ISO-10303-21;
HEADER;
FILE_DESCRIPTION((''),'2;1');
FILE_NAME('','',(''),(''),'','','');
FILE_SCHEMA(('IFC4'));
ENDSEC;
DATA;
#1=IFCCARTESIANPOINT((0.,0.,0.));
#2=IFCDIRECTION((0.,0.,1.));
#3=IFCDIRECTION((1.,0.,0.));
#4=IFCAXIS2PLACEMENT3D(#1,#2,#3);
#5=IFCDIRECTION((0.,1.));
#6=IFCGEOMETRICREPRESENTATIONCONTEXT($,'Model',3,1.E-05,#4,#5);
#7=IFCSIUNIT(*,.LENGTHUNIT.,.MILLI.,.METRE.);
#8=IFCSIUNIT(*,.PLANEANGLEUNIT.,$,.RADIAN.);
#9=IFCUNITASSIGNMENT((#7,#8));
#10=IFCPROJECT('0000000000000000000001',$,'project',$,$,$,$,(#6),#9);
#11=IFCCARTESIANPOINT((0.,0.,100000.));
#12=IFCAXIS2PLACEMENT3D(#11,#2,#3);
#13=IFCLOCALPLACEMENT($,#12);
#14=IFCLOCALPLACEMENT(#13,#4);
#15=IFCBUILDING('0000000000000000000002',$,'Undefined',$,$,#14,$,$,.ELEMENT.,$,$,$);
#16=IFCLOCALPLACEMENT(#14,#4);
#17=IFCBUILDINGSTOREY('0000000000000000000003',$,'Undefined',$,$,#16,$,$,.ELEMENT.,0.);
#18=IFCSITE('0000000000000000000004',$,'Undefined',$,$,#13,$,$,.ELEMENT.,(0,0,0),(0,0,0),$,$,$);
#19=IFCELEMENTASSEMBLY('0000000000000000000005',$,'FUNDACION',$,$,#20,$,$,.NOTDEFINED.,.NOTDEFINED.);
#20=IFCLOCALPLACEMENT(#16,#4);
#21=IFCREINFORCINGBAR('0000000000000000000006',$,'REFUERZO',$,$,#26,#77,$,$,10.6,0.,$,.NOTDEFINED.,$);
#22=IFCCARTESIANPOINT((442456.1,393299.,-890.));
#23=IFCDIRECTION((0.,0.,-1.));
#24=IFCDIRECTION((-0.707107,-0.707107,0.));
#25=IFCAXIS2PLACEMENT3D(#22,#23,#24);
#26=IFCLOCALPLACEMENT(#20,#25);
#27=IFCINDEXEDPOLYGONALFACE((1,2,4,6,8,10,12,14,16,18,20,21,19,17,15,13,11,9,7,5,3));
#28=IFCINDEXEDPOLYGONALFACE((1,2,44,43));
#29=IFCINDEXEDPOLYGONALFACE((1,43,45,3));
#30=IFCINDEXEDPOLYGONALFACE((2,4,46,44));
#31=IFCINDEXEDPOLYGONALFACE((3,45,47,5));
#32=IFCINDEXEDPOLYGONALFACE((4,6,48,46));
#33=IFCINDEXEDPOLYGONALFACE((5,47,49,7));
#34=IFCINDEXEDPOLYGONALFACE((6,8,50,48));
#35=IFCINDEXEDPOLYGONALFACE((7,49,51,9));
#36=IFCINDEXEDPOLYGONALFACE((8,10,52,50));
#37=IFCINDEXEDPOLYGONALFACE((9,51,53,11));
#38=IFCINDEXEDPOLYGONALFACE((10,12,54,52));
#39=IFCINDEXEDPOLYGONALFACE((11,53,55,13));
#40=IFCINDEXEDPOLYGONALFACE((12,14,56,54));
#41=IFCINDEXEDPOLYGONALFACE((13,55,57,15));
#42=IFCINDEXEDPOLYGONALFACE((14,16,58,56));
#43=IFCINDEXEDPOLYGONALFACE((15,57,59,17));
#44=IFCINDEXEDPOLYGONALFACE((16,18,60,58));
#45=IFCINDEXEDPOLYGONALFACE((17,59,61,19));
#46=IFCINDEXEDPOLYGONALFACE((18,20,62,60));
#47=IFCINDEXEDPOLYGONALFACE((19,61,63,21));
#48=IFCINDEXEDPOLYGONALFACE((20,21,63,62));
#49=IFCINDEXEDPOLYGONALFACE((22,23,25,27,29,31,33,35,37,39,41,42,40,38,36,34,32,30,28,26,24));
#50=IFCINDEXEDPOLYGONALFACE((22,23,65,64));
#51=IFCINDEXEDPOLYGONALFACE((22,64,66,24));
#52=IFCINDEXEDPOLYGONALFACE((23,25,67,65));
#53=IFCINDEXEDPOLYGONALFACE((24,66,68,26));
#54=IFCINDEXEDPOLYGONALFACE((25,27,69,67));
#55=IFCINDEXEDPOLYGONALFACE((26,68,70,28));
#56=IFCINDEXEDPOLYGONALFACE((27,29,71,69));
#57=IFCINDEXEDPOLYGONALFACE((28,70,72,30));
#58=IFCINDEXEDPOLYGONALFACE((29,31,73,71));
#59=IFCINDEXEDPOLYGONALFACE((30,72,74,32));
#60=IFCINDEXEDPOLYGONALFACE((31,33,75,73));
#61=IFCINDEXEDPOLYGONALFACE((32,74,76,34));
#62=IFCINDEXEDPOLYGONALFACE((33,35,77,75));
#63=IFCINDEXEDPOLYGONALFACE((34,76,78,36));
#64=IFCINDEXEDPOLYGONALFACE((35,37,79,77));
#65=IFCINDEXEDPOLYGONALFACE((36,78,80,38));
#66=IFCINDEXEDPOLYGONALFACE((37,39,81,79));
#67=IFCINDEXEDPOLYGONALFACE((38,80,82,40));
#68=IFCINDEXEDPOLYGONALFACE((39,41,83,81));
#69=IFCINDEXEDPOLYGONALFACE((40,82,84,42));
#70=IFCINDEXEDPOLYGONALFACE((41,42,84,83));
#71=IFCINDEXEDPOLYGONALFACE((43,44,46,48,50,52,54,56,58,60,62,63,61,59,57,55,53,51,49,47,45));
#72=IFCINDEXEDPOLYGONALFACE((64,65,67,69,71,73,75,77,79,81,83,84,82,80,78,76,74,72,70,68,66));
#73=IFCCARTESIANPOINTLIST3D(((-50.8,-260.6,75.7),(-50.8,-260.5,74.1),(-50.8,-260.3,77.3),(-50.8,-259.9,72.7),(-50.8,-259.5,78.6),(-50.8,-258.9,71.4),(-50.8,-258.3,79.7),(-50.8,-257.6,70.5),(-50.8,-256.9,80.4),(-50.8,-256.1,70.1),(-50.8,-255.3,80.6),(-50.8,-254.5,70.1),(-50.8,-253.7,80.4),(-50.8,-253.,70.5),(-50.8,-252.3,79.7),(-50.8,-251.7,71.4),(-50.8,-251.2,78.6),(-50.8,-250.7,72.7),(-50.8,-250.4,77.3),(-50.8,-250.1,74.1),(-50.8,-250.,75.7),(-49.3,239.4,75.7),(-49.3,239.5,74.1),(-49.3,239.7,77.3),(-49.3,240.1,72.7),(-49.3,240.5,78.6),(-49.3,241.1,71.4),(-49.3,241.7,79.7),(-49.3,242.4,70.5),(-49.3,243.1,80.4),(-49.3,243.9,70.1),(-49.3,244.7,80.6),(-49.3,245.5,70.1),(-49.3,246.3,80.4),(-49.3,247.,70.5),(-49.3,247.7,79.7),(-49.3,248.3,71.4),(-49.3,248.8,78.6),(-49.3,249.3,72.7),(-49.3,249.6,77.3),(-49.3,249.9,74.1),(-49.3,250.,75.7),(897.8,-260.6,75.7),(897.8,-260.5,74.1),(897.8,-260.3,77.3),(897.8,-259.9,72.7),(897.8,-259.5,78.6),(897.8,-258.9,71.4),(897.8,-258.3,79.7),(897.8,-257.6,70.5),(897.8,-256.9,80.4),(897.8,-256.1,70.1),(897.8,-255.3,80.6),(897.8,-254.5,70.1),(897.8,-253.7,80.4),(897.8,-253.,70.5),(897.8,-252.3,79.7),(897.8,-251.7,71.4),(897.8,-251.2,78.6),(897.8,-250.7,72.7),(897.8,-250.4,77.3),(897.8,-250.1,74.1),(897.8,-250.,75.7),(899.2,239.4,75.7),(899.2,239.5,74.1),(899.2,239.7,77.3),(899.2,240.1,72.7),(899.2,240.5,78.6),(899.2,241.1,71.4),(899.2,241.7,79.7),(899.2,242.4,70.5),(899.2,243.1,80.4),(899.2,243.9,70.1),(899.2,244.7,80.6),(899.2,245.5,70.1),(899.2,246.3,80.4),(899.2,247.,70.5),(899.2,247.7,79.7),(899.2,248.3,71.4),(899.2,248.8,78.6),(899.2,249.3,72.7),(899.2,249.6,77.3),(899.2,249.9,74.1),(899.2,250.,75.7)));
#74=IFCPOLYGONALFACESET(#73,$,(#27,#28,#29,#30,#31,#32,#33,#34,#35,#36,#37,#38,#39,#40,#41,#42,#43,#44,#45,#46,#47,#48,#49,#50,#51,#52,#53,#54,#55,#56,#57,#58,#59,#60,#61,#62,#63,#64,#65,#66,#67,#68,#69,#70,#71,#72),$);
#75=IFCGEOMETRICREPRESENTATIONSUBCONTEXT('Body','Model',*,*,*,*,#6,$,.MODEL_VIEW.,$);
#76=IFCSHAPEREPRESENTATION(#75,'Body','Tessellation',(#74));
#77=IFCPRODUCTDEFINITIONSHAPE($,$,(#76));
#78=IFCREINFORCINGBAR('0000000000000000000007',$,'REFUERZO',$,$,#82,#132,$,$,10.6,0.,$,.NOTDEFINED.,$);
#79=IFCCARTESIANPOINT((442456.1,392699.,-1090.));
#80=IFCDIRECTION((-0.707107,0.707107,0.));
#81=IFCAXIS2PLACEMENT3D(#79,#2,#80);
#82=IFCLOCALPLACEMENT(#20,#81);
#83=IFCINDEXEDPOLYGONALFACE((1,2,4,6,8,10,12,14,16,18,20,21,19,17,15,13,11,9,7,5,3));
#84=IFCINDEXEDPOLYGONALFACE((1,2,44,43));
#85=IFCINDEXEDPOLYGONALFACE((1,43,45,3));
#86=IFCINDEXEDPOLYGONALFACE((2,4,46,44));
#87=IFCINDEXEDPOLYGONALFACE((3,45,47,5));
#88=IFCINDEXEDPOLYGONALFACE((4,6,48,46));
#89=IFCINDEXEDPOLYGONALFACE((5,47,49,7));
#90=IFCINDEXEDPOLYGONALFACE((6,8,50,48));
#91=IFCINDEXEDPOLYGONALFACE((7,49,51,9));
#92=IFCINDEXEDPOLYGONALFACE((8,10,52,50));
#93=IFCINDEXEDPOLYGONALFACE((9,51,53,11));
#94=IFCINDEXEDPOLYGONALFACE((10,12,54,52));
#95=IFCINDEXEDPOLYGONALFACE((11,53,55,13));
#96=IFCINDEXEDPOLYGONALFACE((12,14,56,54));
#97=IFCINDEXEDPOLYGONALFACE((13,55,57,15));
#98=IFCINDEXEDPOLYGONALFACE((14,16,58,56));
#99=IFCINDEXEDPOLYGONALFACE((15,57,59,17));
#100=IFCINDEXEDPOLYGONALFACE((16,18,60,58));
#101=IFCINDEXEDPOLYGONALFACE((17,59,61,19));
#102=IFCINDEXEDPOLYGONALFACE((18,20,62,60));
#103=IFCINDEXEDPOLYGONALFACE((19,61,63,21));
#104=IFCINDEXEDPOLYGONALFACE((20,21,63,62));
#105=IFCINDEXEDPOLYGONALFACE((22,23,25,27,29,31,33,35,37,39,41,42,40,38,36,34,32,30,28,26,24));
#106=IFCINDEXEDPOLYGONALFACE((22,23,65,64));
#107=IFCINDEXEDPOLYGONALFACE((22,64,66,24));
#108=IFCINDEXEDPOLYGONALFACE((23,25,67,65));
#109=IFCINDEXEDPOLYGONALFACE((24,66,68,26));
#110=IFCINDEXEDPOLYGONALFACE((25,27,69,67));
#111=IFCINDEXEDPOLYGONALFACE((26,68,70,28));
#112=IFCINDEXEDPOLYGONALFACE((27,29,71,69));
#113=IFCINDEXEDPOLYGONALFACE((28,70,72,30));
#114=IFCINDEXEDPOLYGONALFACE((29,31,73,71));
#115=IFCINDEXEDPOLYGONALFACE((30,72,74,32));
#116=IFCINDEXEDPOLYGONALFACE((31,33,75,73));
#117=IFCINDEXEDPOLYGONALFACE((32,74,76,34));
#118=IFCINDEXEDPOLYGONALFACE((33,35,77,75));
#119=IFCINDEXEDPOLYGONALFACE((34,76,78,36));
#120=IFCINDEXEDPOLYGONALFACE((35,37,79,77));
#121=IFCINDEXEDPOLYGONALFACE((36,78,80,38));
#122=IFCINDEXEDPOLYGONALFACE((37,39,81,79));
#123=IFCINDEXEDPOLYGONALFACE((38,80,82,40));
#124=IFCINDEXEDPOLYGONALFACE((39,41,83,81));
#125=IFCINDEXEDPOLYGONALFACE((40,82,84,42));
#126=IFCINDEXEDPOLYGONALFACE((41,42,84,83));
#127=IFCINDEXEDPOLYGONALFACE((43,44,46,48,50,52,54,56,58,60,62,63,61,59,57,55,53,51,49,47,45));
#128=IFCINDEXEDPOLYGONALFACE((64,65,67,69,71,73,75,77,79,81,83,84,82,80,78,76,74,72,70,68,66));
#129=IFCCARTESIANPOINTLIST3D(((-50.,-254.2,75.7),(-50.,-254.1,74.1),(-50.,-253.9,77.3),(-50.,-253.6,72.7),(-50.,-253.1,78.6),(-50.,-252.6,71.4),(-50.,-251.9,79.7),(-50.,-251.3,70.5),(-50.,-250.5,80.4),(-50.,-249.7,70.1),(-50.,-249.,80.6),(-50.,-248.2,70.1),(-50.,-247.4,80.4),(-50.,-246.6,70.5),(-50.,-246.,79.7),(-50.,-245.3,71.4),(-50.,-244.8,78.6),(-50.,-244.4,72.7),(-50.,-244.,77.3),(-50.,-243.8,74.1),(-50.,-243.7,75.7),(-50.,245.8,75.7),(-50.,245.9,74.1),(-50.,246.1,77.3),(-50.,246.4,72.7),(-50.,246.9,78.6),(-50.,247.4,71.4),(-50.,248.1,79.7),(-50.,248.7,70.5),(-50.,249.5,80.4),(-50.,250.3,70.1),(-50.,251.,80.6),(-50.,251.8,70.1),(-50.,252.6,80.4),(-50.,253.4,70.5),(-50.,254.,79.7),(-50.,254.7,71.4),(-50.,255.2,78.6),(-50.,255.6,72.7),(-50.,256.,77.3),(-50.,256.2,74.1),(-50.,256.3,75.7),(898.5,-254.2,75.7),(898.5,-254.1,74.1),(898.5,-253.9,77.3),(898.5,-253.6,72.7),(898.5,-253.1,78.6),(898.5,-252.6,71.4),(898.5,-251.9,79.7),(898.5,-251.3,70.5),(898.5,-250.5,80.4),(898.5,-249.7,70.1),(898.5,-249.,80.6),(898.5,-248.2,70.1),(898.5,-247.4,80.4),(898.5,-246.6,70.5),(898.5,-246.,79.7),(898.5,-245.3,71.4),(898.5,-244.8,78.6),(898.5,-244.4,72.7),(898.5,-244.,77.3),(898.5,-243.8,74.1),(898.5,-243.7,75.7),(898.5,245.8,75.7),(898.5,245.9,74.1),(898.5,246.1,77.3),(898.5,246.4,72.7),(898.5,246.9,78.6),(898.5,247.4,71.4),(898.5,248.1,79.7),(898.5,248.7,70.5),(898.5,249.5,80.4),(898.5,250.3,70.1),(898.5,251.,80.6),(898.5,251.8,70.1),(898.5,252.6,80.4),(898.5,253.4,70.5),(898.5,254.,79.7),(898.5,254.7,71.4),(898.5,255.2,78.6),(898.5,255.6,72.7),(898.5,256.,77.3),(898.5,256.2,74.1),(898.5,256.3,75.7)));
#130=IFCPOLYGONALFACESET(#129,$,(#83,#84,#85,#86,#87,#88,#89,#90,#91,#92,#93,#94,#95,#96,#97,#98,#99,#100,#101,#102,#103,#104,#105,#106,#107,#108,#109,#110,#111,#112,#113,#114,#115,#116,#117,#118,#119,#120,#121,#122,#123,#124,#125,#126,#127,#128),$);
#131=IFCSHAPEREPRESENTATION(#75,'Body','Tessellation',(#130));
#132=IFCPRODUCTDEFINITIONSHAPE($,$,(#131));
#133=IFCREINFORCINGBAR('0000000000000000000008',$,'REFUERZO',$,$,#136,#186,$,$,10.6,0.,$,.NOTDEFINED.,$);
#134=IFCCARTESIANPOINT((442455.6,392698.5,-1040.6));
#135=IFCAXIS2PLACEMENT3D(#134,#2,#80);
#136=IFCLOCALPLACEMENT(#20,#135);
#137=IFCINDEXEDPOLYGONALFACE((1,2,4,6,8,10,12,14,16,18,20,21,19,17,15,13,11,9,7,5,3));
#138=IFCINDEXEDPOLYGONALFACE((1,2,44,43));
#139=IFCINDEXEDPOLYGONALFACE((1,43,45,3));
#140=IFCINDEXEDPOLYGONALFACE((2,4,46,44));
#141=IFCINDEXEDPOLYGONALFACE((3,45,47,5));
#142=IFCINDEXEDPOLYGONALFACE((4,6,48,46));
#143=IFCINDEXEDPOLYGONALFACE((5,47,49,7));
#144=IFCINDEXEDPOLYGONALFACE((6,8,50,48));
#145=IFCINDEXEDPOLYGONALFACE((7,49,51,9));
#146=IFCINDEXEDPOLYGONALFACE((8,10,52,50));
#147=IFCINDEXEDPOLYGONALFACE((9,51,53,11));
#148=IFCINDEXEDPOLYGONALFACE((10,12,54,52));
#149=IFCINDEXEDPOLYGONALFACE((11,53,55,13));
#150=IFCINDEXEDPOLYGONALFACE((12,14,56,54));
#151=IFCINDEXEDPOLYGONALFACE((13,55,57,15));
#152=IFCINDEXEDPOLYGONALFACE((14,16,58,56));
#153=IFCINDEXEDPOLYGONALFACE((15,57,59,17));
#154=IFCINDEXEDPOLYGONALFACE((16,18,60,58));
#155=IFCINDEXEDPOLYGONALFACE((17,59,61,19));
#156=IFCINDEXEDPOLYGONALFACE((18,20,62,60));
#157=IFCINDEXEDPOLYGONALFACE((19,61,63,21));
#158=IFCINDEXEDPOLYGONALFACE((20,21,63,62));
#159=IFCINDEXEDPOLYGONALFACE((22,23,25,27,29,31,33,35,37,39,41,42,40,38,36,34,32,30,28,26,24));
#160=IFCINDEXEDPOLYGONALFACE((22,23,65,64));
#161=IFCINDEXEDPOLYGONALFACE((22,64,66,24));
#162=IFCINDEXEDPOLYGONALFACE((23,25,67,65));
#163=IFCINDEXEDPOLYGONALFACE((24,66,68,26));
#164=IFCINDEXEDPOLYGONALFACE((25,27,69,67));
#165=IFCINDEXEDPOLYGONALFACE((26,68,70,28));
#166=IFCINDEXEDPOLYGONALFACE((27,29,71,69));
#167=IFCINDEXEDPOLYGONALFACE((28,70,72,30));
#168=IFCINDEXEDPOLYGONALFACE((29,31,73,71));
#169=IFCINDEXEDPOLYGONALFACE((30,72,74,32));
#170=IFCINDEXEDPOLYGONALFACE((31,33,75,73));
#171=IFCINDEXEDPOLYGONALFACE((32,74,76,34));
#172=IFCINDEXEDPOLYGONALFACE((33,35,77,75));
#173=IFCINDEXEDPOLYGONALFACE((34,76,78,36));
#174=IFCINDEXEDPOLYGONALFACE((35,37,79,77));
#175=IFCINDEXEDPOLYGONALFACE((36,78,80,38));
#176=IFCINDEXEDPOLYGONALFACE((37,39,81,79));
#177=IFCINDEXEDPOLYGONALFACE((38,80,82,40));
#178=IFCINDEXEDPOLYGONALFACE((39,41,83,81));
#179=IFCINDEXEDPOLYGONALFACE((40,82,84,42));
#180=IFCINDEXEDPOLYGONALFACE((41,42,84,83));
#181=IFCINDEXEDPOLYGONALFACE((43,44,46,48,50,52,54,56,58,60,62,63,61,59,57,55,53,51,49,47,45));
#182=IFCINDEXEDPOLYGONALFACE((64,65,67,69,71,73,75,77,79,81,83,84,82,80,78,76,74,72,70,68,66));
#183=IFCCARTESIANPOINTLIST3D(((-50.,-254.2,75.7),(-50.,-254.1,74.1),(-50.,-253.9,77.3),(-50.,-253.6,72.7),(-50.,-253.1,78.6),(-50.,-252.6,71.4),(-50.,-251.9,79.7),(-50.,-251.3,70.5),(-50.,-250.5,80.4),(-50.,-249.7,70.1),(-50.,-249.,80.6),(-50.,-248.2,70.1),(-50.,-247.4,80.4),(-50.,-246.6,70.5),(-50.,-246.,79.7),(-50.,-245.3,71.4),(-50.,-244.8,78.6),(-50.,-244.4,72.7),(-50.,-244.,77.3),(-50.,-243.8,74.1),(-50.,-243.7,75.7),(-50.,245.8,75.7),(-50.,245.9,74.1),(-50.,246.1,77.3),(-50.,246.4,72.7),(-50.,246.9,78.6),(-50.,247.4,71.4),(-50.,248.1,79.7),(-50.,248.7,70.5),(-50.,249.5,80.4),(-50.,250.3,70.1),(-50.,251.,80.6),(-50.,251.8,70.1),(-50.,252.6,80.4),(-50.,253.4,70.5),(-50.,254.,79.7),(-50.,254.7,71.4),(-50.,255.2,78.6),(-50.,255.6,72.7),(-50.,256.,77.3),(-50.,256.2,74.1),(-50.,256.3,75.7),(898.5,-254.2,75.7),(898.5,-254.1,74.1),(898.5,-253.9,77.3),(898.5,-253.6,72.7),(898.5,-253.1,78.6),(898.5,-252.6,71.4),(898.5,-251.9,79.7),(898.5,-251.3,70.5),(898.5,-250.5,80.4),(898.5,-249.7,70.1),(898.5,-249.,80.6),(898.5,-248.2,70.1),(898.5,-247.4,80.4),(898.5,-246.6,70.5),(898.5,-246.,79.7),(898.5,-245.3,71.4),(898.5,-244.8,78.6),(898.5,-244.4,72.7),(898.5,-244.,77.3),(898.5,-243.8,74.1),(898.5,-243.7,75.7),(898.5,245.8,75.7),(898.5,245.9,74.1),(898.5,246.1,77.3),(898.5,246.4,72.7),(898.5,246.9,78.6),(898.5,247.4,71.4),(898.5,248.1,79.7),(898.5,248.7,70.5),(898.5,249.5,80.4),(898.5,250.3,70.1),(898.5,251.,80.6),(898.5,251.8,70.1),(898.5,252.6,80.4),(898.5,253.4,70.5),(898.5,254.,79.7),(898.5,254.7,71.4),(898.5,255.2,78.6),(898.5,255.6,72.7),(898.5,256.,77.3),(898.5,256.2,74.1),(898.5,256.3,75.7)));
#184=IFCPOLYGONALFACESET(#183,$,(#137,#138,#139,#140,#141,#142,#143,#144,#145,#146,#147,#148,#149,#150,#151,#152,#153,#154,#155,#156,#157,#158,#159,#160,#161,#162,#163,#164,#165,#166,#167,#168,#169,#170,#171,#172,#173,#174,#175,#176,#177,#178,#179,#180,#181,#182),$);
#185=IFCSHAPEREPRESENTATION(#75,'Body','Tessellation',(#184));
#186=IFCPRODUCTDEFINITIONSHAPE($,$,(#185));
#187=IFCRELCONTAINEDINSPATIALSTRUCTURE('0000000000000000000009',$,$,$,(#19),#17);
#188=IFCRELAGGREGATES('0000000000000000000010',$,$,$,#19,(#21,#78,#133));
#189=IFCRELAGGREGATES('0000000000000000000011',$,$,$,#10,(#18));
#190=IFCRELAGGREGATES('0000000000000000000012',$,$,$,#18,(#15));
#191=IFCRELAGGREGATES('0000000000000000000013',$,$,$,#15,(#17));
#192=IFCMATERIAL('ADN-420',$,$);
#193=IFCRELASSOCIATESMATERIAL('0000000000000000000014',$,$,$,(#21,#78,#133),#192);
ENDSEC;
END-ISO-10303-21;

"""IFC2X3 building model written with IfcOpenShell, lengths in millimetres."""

from ifc_helpers import new_model, entity, si_unit, direction, frame, origin_with_axes, place, context, subcontext, project, spatial, source, transform, mapped, material, element, aggregate, save


model = new_model("IFC2X3")

# Units and contexts
model_context = context("Model", 3, precision=1e-05, world=origin_with_axes(), true_north=direction((0.0, 1.0)))
body_context = subcontext(model_context, "Body", "Model", "MODEL_VIEW")
ifc_project = project(units=[si_unit("LENGTHUNIT", "METRE", prefix="MILLI"), si_unit("PLANEANGLEUNIT", "RADIAN")], contexts=[model_context])

# Site, building, storey
site_placement = place(None, frame((0.0, 0.0, 100000.0), z_axis=(0.0, 0.0, 1.0), x_axis=(1.0, 0.0, 0.0)))
site = spatial("IfcSite", under=ifc_project, at=site_placement, Name="Undefined", CompositionType="ELEMENT", RefLatitude=(0, 0, 0), RefLongitude=(0, 0, 0))
building_placement = place(site_placement, origin_with_axes())
building = spatial("IfcBuilding", under=site, at=building_placement, Name="Undefined", CompositionType="ELEMENT")
storey_placement = place(building_placement, origin_with_axes())
storey = spatial("IfcBuildingStorey", under=building, at=storey_placement, Name="Undefined", CompositionType="ELEMENT", Elevation=0.0)

# Element assembly, reinforcing bars
assembly_1_placement = place(storey_placement, origin_with_axes())
assembly_1 = element("IfcElementAssembly", 1, at=assembly_1_placement, inside=storey, Name="FUNDACION", AssemblyPlace="NOTDEFINED", PredefinedType="NOTDEFINED")
ifc_material_1 = material(Name="ADN-420")
shared_shape_1 = source(origin_with_axes(), body_context, "Body", "AdvancedSweptSolid", [
    entity("IfcSweptDiskSolid", entity("IfcTrimmedCurve", entity("IfcLine", entity("IfcCartesianPoint", [0.0, 0.0, 0.0]), entity("IfcVector", entity("IfcDirection", [1.0, 0.0, 0.0]), 1.0)), [entity("IfcParameterValue", 0.0)], [entity("IfcParameterValue", 948.528137)], True, "PARAMETER"), 5.3, None, 0.0, 948.5),
])
shared_shape_2 = source(origin_with_axes(), body_context, "Body", "AdvancedSweptSolid", [
    entity("IfcSweptDiskSolid", entity("IfcTrimmedCurve", entity("IfcLine", entity("IfcCartesianPoint", [0.0, 0.0, 0.0]), entity("IfcVector", entity("IfcDirection", [1.0, 0.0, 0.0]), 1.0)), [entity("IfcParameterValue", 0.0)], [entity("IfcParameterValue", 948.528137)], True, "PARAMETER"), 5.3, None, 0.0, 948.5),
])
reinforcing_bar_1_placement = place(assembly_1_placement, frame((442456.1, 393299.0, -890.0), z_axis=(0.0, 0.0, -1.0), x_axis=(-0.707107, -0.707107, 0.0)))
reinforcing_bar_1 = element("IfcReinforcingBar", 2, at=reinforcing_bar_1_placement, material=ifc_material_1, Name="REFUERZO", BarRole="NOTDEFINED", CrossSectionArea=0.0, NominalDiameter=10.6, context=body_context, shape_type="MappedRepresentation", body=[
    mapped(shared_shape_1, transform((-50.8, -255.3, 75.3))),
    mapped(shared_shape_2, transform((-49.3, 244.7, 75.3))),
])
shared_shape_3 = source(origin_with_axes(), body_context, "Body", "AdvancedSweptSolid", [
    entity("IfcSweptDiskSolid", entity("IfcTrimmedCurve", entity("IfcLine", entity("IfcCartesianPoint", [0.0, 0.0, 0.0]), entity("IfcVector", entity("IfcDirection", [1.0, 0.0, 0.0]), 1.0)), [entity("IfcParameterValue", 0.0)], [entity("IfcParameterValue", 948.528137)], True, "PARAMETER"), 5.3, None, 0.0, 948.5),
])
shared_shape_4 = source(origin_with_axes(), body_context, "Body", "AdvancedSweptSolid", [
    entity("IfcSweptDiskSolid", entity("IfcTrimmedCurve", entity("IfcLine", entity("IfcCartesianPoint", [0.0, 0.0, 0.0]), entity("IfcVector", entity("IfcDirection", [1.0, 0.0, 0.0]), 1.0)), [entity("IfcParameterValue", 0.0)], [entity("IfcParameterValue", 948.528137)], True, "PARAMETER"), 5.3, None, 0.0, 948.5),
])
reinforcing_bar_2_placement = place(assembly_1_placement, frame((442456.1, 392699.0, -1090.0), z_axis=(0.0, 0.0, 1.0), x_axis=(-0.707107, 0.707107, 0.0)))
reinforcing_bar_2 = element("IfcReinforcingBar", 3, at=reinforcing_bar_2_placement, material=ifc_material_1, Name="REFUERZO", BarRole="NOTDEFINED", CrossSectionArea=0.0, NominalDiameter=10.6, context=body_context, shape_type="MappedRepresentation", body=[
    mapped(shared_shape_3, transform((-50.0, -249.0, 75.3))),
    mapped(shared_shape_4, transform((-50.0, 251.0, 75.3))),
])
shared_shape_5 = source(origin_with_axes(), body_context, "Body", "AdvancedSweptSolid", [
    entity("IfcSweptDiskSolid", entity("IfcTrimmedCurve", entity("IfcLine", entity("IfcCartesianPoint", [0.0, 0.0, 0.0]), entity("IfcVector", entity("IfcDirection", [1.0, 0.0, 0.0]), 1.0)), [entity("IfcParameterValue", 0.0)], [entity("IfcParameterValue", 948.528137)], True, "PARAMETER"), 5.3, None, 0.0, 948.5),
])
shared_shape_6 = source(origin_with_axes(), body_context, "Body", "AdvancedSweptSolid", [
    entity("IfcSweptDiskSolid", entity("IfcTrimmedCurve", entity("IfcLine", entity("IfcCartesianPoint", [0.0, 0.0, 0.0]), entity("IfcVector", entity("IfcDirection", [1.0, 0.0, 0.0]), 1.0)), [entity("IfcParameterValue", 0.0)], [entity("IfcParameterValue", 948.528137)], True, "PARAMETER"), 5.3, None, 0.0, 948.5),
])
reinforcing_bar_3_placement = place(assembly_1_placement, frame((442455.6, 392698.5, -1040.6), z_axis=(0.0, 0.0, 1.0), x_axis=(-0.707107, 0.707107, 0.0)))
reinforcing_bar_3 = element("IfcReinforcingBar", 4, at=reinforcing_bar_3_placement, material=ifc_material_1, Name="REFUERZO", BarRole="NOTDEFINED", CrossSectionArea=0.0, NominalDiameter=10.6, context=body_context, shape_type="MappedRepresentation", body=[
    mapped(shared_shape_5, transform((-50.0, -249.0, 75.3))),
    mapped(shared_shape_6, transform((-50.0, 251.0, 75.3))),
])
aggregate(assembly_1, [reinforcing_bar_1, reinforcing_bar_2, reinforcing_bar_3])

save(model, "model.ifc")
